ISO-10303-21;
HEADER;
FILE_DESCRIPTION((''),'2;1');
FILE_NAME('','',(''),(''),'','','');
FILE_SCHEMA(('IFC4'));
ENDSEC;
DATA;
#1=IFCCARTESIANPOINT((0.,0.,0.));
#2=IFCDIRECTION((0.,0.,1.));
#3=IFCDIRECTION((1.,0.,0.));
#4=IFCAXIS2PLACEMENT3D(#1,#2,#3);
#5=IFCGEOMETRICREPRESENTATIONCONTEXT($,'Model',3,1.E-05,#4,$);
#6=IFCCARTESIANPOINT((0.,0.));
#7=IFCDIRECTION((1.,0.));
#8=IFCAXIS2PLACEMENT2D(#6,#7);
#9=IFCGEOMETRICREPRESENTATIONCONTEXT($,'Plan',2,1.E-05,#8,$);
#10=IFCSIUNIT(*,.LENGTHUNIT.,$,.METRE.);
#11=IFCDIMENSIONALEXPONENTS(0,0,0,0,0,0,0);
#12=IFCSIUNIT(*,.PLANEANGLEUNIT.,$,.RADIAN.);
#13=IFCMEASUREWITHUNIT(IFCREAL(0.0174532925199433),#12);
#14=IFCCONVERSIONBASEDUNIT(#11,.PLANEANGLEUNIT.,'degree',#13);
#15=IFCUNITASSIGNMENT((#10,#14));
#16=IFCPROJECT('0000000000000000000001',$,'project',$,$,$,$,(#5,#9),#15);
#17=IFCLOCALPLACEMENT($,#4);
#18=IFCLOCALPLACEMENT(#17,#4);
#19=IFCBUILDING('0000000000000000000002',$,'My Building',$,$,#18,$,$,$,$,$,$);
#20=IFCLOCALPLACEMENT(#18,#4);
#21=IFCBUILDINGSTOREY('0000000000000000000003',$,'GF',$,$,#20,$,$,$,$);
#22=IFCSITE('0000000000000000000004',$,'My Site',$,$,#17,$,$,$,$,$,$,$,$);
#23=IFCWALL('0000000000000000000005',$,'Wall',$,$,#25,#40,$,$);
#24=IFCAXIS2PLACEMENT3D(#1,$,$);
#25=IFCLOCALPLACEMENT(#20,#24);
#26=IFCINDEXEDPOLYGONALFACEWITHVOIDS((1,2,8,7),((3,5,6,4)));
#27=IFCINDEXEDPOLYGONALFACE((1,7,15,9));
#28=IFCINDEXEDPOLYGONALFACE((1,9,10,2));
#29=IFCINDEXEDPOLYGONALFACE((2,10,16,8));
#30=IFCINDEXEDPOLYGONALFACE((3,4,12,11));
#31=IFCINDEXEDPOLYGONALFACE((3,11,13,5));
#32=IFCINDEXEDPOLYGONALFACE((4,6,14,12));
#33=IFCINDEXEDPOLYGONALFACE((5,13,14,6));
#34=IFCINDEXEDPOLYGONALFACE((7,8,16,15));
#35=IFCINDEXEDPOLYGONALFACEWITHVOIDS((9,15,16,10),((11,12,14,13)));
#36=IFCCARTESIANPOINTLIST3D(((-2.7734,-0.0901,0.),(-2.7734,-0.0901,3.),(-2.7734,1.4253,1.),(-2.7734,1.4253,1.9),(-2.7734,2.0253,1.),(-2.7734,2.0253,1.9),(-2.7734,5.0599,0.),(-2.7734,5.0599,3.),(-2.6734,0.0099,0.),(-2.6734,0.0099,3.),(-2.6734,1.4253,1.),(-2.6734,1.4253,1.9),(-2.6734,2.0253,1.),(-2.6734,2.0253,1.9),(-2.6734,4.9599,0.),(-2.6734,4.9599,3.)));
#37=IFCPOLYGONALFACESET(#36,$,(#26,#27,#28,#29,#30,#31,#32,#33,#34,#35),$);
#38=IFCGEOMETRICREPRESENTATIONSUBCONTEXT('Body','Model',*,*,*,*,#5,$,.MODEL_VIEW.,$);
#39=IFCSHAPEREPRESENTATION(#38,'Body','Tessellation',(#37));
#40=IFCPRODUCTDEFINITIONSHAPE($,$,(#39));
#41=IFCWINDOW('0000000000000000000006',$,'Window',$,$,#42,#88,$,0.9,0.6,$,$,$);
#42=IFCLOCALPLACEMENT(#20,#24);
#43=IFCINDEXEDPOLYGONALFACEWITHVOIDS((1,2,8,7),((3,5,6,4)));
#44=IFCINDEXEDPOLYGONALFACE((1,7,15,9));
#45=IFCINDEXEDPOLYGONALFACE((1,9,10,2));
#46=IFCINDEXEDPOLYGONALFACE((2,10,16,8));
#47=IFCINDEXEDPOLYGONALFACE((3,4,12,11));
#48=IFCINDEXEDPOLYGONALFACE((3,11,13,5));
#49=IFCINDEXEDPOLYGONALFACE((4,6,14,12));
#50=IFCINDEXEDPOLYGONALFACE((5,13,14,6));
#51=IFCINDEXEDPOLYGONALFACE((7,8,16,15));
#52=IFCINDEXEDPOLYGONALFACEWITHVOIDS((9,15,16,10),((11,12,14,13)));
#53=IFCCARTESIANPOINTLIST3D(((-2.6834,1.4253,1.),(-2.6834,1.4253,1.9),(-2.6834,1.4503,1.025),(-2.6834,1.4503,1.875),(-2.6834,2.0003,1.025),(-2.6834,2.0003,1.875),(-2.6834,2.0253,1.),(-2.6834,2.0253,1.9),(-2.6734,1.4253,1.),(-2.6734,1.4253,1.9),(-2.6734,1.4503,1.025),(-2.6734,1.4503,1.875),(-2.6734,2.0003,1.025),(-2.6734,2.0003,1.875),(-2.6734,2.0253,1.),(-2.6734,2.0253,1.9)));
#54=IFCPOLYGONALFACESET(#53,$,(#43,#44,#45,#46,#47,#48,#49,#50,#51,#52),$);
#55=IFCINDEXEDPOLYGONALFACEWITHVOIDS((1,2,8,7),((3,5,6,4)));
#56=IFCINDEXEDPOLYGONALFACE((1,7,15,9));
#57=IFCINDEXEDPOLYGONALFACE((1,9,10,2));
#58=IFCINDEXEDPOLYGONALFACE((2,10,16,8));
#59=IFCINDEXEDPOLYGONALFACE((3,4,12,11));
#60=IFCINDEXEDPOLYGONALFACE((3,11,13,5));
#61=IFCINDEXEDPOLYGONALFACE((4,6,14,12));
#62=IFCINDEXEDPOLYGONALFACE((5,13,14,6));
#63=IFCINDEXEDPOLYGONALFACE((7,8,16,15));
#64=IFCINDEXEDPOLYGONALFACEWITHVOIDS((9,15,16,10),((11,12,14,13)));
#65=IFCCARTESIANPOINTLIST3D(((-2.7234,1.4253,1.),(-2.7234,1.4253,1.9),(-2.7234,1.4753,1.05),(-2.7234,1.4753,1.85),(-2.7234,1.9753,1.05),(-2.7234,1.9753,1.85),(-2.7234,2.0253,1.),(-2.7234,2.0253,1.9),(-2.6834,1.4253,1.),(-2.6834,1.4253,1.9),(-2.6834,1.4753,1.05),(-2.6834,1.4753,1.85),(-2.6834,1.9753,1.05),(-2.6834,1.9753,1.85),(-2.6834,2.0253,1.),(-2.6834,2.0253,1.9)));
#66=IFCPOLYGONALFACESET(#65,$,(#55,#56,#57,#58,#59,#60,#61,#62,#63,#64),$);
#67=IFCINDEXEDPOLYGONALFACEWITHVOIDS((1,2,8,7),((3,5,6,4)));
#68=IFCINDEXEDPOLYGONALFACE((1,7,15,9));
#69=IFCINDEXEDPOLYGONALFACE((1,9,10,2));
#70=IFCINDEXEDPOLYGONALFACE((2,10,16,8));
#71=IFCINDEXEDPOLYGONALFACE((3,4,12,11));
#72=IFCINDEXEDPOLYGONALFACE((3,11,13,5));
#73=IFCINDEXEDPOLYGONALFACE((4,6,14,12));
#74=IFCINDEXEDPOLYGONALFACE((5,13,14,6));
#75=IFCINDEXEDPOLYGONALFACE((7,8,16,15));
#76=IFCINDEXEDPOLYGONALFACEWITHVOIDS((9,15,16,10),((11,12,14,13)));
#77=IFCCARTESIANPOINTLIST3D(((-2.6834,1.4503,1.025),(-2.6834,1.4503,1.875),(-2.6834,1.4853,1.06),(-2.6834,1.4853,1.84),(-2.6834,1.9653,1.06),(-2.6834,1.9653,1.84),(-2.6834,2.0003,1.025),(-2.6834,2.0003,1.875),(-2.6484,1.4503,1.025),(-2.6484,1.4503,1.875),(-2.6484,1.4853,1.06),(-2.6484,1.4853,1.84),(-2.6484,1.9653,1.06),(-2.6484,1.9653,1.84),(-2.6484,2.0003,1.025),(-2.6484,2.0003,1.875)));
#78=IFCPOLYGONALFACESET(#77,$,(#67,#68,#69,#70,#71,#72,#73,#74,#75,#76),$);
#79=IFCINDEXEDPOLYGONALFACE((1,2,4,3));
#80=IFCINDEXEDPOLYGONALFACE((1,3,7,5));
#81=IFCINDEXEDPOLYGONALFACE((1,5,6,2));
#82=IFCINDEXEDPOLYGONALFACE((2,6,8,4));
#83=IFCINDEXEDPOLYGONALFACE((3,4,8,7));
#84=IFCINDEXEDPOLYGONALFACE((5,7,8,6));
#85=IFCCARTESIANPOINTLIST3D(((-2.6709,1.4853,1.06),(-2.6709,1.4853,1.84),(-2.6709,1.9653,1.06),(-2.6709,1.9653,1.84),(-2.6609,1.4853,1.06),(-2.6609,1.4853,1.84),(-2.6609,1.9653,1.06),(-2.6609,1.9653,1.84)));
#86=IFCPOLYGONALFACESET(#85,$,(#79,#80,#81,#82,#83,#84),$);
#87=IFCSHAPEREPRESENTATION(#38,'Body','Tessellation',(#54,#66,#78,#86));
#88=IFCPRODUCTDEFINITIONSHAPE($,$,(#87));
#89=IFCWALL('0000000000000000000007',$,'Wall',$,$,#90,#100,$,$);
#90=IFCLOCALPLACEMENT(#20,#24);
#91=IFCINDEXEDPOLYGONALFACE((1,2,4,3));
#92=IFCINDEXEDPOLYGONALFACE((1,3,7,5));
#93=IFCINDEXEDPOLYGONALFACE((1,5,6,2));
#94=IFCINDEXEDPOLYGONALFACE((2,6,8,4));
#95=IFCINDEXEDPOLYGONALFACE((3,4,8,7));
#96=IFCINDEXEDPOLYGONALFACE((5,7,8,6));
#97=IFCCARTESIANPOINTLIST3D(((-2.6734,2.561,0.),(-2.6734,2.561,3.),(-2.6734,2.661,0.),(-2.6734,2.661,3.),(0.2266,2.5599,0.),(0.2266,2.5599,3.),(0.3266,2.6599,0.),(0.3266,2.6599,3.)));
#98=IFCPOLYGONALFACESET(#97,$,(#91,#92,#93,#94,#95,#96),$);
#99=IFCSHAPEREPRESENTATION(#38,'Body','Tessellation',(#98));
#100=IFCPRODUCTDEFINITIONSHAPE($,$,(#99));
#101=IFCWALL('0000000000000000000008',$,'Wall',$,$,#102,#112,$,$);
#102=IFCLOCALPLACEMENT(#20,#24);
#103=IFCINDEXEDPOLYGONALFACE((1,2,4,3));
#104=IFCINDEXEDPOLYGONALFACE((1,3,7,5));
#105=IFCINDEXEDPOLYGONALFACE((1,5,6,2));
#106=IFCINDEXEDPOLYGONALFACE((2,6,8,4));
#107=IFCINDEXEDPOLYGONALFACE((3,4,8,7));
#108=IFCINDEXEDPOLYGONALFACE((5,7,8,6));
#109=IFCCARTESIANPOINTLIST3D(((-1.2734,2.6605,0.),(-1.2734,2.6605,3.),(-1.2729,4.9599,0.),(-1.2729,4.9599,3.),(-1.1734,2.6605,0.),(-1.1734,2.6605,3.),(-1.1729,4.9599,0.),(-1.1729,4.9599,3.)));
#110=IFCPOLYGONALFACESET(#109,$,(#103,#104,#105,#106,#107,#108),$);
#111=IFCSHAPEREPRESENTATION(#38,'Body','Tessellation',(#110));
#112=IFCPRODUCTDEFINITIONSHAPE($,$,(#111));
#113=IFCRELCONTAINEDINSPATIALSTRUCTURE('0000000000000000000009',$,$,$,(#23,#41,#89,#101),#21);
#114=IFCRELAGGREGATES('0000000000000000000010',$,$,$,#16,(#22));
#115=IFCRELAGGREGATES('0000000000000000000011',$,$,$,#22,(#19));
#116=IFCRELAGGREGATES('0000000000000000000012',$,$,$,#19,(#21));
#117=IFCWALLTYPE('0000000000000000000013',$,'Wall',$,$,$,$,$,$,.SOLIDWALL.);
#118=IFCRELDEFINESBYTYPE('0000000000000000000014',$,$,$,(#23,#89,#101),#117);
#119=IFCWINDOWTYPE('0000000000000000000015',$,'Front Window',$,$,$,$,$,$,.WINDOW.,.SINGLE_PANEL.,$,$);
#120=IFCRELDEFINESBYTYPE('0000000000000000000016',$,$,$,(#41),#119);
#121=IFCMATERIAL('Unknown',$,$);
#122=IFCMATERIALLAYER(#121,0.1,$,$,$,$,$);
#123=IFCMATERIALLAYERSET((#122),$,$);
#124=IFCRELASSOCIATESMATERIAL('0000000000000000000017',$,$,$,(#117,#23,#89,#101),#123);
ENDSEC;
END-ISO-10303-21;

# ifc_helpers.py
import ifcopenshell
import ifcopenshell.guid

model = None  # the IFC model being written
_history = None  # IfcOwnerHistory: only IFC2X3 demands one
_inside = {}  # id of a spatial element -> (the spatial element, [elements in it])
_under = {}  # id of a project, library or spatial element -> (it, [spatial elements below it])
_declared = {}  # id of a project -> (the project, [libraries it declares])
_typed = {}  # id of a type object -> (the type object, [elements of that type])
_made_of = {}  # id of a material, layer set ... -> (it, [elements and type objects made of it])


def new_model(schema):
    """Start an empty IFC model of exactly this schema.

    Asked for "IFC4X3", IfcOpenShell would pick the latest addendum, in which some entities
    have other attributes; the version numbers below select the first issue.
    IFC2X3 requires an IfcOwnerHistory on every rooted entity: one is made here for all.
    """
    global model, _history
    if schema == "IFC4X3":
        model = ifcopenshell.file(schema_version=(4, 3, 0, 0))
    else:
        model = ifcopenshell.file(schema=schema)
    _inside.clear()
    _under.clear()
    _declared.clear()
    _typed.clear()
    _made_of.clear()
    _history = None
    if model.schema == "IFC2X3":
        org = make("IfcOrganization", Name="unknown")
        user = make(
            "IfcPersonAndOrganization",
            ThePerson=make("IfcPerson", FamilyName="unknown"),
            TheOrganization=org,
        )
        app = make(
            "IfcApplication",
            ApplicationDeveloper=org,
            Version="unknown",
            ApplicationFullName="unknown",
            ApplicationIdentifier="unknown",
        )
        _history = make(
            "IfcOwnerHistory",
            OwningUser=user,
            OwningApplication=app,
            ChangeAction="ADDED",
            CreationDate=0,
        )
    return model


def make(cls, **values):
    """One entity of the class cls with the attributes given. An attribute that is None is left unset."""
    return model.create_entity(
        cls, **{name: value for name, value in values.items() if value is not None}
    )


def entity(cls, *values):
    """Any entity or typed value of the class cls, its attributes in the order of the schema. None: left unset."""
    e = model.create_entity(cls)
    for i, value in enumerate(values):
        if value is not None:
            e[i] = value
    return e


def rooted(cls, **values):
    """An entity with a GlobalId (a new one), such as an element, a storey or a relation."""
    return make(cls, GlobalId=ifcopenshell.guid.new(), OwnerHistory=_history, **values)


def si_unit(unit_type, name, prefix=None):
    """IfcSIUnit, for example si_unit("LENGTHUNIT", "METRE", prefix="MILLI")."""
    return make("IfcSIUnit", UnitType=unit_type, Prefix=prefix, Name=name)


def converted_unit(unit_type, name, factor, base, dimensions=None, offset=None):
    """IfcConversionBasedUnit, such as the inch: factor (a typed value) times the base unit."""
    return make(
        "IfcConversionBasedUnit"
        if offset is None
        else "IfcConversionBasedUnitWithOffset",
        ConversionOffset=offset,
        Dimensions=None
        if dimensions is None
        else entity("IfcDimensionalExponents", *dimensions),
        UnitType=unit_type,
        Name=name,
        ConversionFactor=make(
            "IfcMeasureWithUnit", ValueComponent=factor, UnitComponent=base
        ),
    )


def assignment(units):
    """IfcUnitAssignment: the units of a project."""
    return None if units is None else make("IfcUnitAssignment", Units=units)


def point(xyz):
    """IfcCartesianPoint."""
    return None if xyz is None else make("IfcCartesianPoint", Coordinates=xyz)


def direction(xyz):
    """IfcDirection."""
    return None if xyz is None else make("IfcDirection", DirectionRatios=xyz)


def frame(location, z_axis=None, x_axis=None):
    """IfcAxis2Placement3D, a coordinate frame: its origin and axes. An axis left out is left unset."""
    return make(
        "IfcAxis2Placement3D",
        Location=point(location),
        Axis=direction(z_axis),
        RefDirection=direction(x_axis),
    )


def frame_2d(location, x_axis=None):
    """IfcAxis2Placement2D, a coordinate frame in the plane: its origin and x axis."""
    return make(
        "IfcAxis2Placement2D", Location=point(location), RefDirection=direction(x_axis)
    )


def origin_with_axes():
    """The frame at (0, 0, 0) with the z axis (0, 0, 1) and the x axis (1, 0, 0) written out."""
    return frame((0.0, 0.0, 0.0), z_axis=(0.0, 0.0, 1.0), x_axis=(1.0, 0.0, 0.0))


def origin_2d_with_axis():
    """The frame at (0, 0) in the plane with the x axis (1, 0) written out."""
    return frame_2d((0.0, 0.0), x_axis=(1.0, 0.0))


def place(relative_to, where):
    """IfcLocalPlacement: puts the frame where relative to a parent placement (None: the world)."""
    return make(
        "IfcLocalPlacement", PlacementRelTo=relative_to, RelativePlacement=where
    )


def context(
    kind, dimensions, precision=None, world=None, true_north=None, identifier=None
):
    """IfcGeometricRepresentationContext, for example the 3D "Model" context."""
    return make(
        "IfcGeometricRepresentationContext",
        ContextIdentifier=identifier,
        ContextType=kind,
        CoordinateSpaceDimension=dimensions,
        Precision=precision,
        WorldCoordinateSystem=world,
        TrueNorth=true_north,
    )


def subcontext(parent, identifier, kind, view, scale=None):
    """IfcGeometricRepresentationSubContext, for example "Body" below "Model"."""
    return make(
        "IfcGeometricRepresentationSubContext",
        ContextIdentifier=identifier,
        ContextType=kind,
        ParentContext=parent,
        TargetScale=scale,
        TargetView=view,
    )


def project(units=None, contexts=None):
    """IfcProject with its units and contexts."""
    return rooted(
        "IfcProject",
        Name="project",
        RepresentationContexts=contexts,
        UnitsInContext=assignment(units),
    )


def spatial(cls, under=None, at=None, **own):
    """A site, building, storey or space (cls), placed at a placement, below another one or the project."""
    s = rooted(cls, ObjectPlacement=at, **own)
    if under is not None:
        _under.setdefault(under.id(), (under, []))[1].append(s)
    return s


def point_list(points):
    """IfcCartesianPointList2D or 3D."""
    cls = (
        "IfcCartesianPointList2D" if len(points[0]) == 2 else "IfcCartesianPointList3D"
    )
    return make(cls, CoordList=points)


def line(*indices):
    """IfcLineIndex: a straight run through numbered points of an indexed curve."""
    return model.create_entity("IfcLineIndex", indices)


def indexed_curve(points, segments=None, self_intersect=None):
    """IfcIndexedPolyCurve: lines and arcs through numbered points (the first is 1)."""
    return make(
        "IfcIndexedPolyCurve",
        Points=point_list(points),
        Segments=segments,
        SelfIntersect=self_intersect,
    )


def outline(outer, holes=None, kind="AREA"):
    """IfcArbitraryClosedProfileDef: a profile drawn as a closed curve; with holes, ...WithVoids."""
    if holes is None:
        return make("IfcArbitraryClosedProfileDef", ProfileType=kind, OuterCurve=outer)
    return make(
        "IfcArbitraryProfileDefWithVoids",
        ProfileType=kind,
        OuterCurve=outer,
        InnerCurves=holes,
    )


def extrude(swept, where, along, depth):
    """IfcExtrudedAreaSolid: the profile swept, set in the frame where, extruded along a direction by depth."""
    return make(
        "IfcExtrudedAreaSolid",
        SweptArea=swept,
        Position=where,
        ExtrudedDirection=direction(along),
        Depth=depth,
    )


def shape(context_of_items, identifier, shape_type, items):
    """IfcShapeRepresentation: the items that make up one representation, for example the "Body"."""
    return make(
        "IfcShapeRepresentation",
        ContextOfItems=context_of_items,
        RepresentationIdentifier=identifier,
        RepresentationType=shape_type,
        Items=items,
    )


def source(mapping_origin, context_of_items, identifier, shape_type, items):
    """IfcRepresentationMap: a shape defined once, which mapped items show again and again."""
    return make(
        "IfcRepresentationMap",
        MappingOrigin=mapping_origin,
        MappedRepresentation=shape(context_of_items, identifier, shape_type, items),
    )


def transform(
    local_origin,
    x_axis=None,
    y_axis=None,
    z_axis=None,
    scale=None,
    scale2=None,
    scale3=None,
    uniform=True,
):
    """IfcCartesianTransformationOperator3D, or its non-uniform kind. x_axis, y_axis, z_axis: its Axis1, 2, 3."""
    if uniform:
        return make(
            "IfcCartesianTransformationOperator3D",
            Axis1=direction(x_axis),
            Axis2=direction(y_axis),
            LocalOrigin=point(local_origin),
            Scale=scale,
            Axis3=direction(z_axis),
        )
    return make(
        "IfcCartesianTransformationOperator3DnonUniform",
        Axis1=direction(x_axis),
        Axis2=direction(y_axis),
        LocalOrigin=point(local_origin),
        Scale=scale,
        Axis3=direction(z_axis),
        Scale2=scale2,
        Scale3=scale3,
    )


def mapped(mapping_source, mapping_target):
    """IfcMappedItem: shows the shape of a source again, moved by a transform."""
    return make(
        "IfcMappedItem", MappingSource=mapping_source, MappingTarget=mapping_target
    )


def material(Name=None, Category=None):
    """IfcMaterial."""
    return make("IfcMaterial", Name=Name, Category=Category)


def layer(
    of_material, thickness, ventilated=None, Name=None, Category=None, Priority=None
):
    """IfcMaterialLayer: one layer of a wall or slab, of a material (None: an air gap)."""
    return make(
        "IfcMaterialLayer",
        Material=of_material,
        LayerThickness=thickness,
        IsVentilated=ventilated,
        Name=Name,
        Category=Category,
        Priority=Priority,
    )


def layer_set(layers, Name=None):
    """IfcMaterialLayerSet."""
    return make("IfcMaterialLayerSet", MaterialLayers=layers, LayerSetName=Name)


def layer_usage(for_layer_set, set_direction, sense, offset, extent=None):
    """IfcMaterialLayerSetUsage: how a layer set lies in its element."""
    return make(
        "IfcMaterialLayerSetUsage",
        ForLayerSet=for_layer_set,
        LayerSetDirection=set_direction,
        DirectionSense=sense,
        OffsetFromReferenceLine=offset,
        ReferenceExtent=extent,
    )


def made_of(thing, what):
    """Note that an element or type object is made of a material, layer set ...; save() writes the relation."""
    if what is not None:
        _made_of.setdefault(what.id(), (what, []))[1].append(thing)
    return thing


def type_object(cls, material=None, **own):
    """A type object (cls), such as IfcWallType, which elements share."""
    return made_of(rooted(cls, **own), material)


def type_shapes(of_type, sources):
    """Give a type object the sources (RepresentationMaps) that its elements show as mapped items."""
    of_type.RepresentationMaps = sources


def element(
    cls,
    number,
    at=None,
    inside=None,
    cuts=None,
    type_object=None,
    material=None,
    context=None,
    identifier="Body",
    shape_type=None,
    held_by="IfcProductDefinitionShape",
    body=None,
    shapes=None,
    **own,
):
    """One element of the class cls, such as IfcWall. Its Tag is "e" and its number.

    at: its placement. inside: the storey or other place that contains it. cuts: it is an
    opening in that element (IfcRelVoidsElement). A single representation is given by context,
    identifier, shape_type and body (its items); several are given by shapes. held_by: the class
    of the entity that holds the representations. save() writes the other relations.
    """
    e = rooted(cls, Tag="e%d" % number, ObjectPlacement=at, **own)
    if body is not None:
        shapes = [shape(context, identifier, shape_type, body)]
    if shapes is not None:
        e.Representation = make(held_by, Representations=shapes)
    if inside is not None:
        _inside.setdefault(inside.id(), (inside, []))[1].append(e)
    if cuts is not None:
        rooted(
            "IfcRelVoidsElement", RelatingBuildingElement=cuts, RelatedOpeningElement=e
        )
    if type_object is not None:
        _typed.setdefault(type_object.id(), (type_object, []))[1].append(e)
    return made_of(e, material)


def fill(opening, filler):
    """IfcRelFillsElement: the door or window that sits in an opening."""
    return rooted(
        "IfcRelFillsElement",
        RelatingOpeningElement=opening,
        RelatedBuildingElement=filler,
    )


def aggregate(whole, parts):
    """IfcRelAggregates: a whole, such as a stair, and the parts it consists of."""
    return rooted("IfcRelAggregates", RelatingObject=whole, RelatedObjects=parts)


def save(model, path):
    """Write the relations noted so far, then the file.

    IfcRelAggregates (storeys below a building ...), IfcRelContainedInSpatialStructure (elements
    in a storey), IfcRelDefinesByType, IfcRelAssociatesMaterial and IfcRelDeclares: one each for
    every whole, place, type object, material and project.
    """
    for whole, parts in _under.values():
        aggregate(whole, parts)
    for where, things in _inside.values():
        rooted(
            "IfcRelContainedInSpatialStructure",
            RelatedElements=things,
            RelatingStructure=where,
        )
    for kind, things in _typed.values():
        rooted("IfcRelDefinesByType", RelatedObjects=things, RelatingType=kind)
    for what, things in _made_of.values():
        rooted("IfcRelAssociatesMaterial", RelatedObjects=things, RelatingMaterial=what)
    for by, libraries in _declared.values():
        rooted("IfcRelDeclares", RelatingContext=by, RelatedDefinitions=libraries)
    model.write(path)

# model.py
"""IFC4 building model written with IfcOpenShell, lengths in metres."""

from ifc_helpers import new_model, entity, si_unit, converted_unit, frame, origin_with_axes, origin_2d_with_axis, place, context, subcontext, project, spatial, line, indexed_curve, outline, extrude, shape, source, transform, mapped, material, layer, layer_set, layer_usage, type_object, type_shapes, element, fill, save


model = new_model("IFC4")

# Units and contexts
model_context = context("Model", 3, precision=1e-05, world=origin_with_axes())
plan_context = context("Plan", 2, precision=1e-05, world=origin_2d_with_axis())
body_context_1 = subcontext(model_context, "Body", "Model", "MODEL_VIEW")
body_context_2 = subcontext(plan_context, "Body", "Plan", "PLAN_VIEW")
ifc_project = project(units=[si_unit("LENGTHUNIT", "METRE"), converted_unit("PLANEANGLEUNIT", "degree", entity("IfcReal", 0.0174532925199433), si_unit("PLANEANGLEUNIT", "RADIAN"), dimensions=[0, 0, 0, 0, 0, 0, 0])], contexts=[model_context, plan_context])

# Site, building, storey
site_placement = place(None, origin_with_axes())
site = spatial("IfcSite", under=ifc_project, at=site_placement, Name="My Site")
building_placement = place(site_placement, origin_with_axes())
building = spatial("IfcBuilding", under=site, at=building_placement, Name="My Building")
storey_placement = place(building_placement, origin_with_axes())
storey = spatial("IfcBuildingStorey", under=building, at=storey_placement, Name="GF")

# Shared definitions
ifc_material = material(Name="Unknown")

# Shared definitions
ifc_layer = layer(ifc_material, 0.1)
ifc_layer_set = layer_set([ifc_layer])
wall_type = type_object("IfcWallType", Name="Wall", PredefinedType="SOLIDWALL", material=ifc_layer_set)

# Wall, opening, window
ifc_layer_usage_1 = layer_usage(ifc_layer_set, "AXIS2", "POSITIVE", 0.0)
wall_1_placement = place(storey_placement, frame((-2.7734, 5.0599, 0.0), z_axis=(0.0, 0.0, 1.0), x_axis=(0.0, -1.0, 0.0)))
wall_1 = element("IfcWall", 1, at=wall_1_placement, inside=storey, type_object=wall_type, material=ifc_layer_usage_1, Name="Wall", context=body_context_1, shape_type="SweptSolid", body=[
    extrude(outline(indexed_curve([(0.0, 0.0), (0.1, 0.1), (5.05, 0.1), (5.15, 0.0)], segments=[line(1, 2, 3, 4, 1)])), origin_with_axes(), (0.0, 0.0, 1.0), 3.0),
])
shared_shape_1 = source(origin_with_axes(), body_context_1, "Body", "SweptSolid", [
    extrude(outline(indexed_curve([(0.0, 0.0), (0.6, 0.0), (0.6, 0.9), (0.0, 0.9)], segments=[line(1, 2, 3, 4, 1)])), frame((0.0, -0.6, 0.0), z_axis=(0.0, -1.0, 0.0), x_axis=(1.0, 0.0, 0.0)), (0.0, 0.0, -1.0), 1.2),
])
opening_1_placement = place(wall_1_placement, frame((3.0346, 0.0, 1.0), z_axis=(0.0, 0.0, 1.0), x_axis=(1.0, 0.0, 0.0)))
opening_1 = element("IfcOpeningElement", 2, at=opening_1_placement, cuts=wall_1, PredefinedType="OPENING", context=body_context_1, shape_type="MappedRepresentation", body=[
    mapped(shared_shape_1, transform((0.0, 0.0, 0.0), x_axis=(1.0, 0.0, 0.0), y_axis=(0.0, 1.0, 0.0), z_axis=(0.0, 0.0, 1.0), scale=1.0)),
])
window_type_1 = type_object("IfcWindowType", Name="Front Window", PartitioningType="SINGLE_PANEL", PredefinedType="WINDOW")
shared_shape_2 = source(origin_with_axes(), body_context_1, "Body", "SweptSolid", [
    extrude(outline(indexed_curve([(0.0, 0.0), (0.6, 0.0), (0.6, 0.9), (0.0, 0.9)], segments=[line(1, 2, 3, 4, 1)]), holes=[indexed_curve([(0.025, 0.025), (0.575, 0.025), (0.575, 0.875), (0.025, 0.875)], segments=[line(1, 2, 3, 4, 1)])]), frame((0.0, 0.09, 0.0), z_axis=(0.0, -1.0, 0.0), x_axis=(1.0, 0.0, 0.0)), (0.0, 0.0, -1.0), 0.01),
    extrude(outline(indexed_curve([(0.0, 0.0), (0.6, 0.0), (0.6, 0.9), (0.0, 0.9)], segments=[line(1, 2, 3, 4, 1)]), holes=[indexed_curve([(0.05, 0.05), (0.55, 0.05), (0.55, 0.85), (0.05, 0.85)], segments=[line(1, 2, 3, 4, 1)])]), frame((0.0, 0.05, 0.0), z_axis=(0.0, -1.0, 0.0), x_axis=(1.0, 0.0, 0.0)), (0.0, 0.0, -1.0), 0.04),
    extrude(outline(indexed_curve([(0.0, 0.0), (0.55, 0.0), (0.55, 0.85), (0.0, 0.85)], segments=[line(1, 2, 3, 4, 1)]), holes=[indexed_curve([(0.035, 0.035), (0.515, 0.035), (0.515, 0.815), (0.035, 0.815)], segments=[line(1, 2, 3, 4, 1)])]), frame((0.025, 0.09, 0.025), z_axis=(0.0, -1.0, 0.0), x_axis=(1.0, 0.0, 0.0)), (0.0, 0.0, -1.0), 0.035),
    extrude(outline(indexed_curve([(0.035, 0.035), (0.515, 0.035), (0.515, 0.815), (0.035, 0.815)], segments=[line(1, 2, 3, 4, 1)])), frame((0.025, 0.1025, 0.025), z_axis=(0.0, -1.0, 0.0), x_axis=(1.0, 0.0, 0.0)), (0.0, 0.0, -1.0), 0.01),
])
shared_shape_3 = source(origin_with_axes(), body_context_2, "Body", "Curve2D", [
    entity("IfcIndexedPolyCurve", entity("IfcCartesianPointList2D", [[0.05, 0.05], [0.55, 0.05]])),
    entity("IfcIndexedPolyCurve", entity("IfcCartesianPointList2D", [[0.0, 0.1], [0.025, 0.1], [0.025, 0.09], [0.05, 0.09], [0.05, 0.05], [0.0, 0.05]]), [entity("IfcLineIndex", [1, 2, 3, 4, 5, 6, 1])]),
    entity("IfcIndexedPolyCurve", entity("IfcCartesianPointList2D", [[0.6, 0.1], [0.575, 0.1], [0.575, 0.09], [0.55, 0.09], [0.55, 0.05], [0.6, 0.05]]), [entity("IfcLineIndex", [1, 2, 3, 4, 5, 6, 1])]),
    entity("IfcIndexedPolyCurve", entity("IfcCartesianPointList2D", [[0.025, 0.09], [0.06, 0.09], [0.06, 0.125], [0.025, 0.125]]), [entity("IfcLineIndex", [1, 2, 3, 4, 1])]),
    entity("IfcIndexedPolyCurve", entity("IfcCartesianPointList2D", [[0.575, 0.09], [0.54, 0.09], [0.54, 0.125], [0.575, 0.125]]), [entity("IfcLineIndex", [1, 2, 3, 4, 1])]),
    entity("IfcIndexedPolyCurve", entity("IfcCartesianPointList2D", [[0.06, 0.09], [0.54, 0.09]])),
    entity("IfcIndexedPolyCurve", entity("IfcCartesianPointList2D", [[0.06, 0.125], [0.54, 0.125]])),
    entity("IfcIndexedPolyCurve", entity("IfcCartesianPointList2D", [[0.06, 0.1075], [0.54, 0.1075]])),
])
type_shapes(window_type_1, [shared_shape_2, shared_shape_3])
window_1_placement = place(opening_1_placement, frame((0.0, 0.0, 0.0), z_axis=(0.0, 0.0, 1.0), x_axis=(1.0, 0.0, 0.0)))
window_1 = element("IfcWindow", 3, at=window_1_placement, inside=storey, type_object=window_type_1, Name="Window", OverallHeight=0.9, OverallWidth=0.6, shapes=[
    shape(body_context_1, "Body", "MappedRepresentation", [mapped(shared_shape_2, transform((0.0, 0.0, 0.0), x_axis=(1.0, 0.0, 0.0), y_axis=(0.0, 1.0, 0.0), z_axis=(0.0, 0.0, 1.0), scale=1.0))]),
    shape(body_context_2, "Body", "MappedRepresentation", [mapped(shared_shape_3, transform((0.0, 0.0, 0.0), x_axis=(1.0, 0.0, 0.0), y_axis=(0.0, 1.0, 0.0), z_axis=(0.0, 0.0, 1.0), scale=1.0))]),
])
fill(opening_1, window_1)

# Walls
ifc_layer_usage_2 = layer_usage(ifc_layer_set, "AXIS2", "POSITIVE", 0.0)
wall_2_placement = place(storey_placement, frame((0.3266, 2.6599, 0.0), z_axis=(0.0, 0.0, 1.0), x_axis=(-1.0, 0.000381, 0.0)))
element("IfcWall", 4, at=wall_2_placement, inside=storey, type_object=wall_type, material=ifc_layer_usage_2, Name="Wall", context=body_context_1, shape_type="SweptSolid", body=[
    extrude(outline(indexed_curve([(0.0, 0.0), (0.1, 0.1), (3.0, 0.1), (3.0, 0.0)], segments=[line(1, 2, 3, 4, 1)])), origin_with_axes(), (0.0, 0.0, 1.0), 3.0),
])
ifc_layer_usage_3 = layer_usage(ifc_layer_set, "AXIS2", "POSITIVE", 0.0)
wall_3_placement = place(storey_placement, frame((-1.1734, 2.6605, 0.0), z_axis=(0.0, 0.0, 1.0), x_axis=(0.000197, 1.0, 0.0)))
element("IfcWall", 5, at=wall_3_placement, inside=storey, type_object=wall_type, material=ifc_layer_usage_3, Name="Wall", context=body_context_1, shape_type="SweptSolid", body=[
    extrude(outline(indexed_curve([(0.0, 0.0), (0.0, 0.1), (2.2994, 0.1), (2.2994, 0.0)], segments=[line(1, 2, 3, 4, 1)])), origin_with_axes(), (0.0, 0.0, 1.0), 3.0),
])

save(model, "model.ifc")
